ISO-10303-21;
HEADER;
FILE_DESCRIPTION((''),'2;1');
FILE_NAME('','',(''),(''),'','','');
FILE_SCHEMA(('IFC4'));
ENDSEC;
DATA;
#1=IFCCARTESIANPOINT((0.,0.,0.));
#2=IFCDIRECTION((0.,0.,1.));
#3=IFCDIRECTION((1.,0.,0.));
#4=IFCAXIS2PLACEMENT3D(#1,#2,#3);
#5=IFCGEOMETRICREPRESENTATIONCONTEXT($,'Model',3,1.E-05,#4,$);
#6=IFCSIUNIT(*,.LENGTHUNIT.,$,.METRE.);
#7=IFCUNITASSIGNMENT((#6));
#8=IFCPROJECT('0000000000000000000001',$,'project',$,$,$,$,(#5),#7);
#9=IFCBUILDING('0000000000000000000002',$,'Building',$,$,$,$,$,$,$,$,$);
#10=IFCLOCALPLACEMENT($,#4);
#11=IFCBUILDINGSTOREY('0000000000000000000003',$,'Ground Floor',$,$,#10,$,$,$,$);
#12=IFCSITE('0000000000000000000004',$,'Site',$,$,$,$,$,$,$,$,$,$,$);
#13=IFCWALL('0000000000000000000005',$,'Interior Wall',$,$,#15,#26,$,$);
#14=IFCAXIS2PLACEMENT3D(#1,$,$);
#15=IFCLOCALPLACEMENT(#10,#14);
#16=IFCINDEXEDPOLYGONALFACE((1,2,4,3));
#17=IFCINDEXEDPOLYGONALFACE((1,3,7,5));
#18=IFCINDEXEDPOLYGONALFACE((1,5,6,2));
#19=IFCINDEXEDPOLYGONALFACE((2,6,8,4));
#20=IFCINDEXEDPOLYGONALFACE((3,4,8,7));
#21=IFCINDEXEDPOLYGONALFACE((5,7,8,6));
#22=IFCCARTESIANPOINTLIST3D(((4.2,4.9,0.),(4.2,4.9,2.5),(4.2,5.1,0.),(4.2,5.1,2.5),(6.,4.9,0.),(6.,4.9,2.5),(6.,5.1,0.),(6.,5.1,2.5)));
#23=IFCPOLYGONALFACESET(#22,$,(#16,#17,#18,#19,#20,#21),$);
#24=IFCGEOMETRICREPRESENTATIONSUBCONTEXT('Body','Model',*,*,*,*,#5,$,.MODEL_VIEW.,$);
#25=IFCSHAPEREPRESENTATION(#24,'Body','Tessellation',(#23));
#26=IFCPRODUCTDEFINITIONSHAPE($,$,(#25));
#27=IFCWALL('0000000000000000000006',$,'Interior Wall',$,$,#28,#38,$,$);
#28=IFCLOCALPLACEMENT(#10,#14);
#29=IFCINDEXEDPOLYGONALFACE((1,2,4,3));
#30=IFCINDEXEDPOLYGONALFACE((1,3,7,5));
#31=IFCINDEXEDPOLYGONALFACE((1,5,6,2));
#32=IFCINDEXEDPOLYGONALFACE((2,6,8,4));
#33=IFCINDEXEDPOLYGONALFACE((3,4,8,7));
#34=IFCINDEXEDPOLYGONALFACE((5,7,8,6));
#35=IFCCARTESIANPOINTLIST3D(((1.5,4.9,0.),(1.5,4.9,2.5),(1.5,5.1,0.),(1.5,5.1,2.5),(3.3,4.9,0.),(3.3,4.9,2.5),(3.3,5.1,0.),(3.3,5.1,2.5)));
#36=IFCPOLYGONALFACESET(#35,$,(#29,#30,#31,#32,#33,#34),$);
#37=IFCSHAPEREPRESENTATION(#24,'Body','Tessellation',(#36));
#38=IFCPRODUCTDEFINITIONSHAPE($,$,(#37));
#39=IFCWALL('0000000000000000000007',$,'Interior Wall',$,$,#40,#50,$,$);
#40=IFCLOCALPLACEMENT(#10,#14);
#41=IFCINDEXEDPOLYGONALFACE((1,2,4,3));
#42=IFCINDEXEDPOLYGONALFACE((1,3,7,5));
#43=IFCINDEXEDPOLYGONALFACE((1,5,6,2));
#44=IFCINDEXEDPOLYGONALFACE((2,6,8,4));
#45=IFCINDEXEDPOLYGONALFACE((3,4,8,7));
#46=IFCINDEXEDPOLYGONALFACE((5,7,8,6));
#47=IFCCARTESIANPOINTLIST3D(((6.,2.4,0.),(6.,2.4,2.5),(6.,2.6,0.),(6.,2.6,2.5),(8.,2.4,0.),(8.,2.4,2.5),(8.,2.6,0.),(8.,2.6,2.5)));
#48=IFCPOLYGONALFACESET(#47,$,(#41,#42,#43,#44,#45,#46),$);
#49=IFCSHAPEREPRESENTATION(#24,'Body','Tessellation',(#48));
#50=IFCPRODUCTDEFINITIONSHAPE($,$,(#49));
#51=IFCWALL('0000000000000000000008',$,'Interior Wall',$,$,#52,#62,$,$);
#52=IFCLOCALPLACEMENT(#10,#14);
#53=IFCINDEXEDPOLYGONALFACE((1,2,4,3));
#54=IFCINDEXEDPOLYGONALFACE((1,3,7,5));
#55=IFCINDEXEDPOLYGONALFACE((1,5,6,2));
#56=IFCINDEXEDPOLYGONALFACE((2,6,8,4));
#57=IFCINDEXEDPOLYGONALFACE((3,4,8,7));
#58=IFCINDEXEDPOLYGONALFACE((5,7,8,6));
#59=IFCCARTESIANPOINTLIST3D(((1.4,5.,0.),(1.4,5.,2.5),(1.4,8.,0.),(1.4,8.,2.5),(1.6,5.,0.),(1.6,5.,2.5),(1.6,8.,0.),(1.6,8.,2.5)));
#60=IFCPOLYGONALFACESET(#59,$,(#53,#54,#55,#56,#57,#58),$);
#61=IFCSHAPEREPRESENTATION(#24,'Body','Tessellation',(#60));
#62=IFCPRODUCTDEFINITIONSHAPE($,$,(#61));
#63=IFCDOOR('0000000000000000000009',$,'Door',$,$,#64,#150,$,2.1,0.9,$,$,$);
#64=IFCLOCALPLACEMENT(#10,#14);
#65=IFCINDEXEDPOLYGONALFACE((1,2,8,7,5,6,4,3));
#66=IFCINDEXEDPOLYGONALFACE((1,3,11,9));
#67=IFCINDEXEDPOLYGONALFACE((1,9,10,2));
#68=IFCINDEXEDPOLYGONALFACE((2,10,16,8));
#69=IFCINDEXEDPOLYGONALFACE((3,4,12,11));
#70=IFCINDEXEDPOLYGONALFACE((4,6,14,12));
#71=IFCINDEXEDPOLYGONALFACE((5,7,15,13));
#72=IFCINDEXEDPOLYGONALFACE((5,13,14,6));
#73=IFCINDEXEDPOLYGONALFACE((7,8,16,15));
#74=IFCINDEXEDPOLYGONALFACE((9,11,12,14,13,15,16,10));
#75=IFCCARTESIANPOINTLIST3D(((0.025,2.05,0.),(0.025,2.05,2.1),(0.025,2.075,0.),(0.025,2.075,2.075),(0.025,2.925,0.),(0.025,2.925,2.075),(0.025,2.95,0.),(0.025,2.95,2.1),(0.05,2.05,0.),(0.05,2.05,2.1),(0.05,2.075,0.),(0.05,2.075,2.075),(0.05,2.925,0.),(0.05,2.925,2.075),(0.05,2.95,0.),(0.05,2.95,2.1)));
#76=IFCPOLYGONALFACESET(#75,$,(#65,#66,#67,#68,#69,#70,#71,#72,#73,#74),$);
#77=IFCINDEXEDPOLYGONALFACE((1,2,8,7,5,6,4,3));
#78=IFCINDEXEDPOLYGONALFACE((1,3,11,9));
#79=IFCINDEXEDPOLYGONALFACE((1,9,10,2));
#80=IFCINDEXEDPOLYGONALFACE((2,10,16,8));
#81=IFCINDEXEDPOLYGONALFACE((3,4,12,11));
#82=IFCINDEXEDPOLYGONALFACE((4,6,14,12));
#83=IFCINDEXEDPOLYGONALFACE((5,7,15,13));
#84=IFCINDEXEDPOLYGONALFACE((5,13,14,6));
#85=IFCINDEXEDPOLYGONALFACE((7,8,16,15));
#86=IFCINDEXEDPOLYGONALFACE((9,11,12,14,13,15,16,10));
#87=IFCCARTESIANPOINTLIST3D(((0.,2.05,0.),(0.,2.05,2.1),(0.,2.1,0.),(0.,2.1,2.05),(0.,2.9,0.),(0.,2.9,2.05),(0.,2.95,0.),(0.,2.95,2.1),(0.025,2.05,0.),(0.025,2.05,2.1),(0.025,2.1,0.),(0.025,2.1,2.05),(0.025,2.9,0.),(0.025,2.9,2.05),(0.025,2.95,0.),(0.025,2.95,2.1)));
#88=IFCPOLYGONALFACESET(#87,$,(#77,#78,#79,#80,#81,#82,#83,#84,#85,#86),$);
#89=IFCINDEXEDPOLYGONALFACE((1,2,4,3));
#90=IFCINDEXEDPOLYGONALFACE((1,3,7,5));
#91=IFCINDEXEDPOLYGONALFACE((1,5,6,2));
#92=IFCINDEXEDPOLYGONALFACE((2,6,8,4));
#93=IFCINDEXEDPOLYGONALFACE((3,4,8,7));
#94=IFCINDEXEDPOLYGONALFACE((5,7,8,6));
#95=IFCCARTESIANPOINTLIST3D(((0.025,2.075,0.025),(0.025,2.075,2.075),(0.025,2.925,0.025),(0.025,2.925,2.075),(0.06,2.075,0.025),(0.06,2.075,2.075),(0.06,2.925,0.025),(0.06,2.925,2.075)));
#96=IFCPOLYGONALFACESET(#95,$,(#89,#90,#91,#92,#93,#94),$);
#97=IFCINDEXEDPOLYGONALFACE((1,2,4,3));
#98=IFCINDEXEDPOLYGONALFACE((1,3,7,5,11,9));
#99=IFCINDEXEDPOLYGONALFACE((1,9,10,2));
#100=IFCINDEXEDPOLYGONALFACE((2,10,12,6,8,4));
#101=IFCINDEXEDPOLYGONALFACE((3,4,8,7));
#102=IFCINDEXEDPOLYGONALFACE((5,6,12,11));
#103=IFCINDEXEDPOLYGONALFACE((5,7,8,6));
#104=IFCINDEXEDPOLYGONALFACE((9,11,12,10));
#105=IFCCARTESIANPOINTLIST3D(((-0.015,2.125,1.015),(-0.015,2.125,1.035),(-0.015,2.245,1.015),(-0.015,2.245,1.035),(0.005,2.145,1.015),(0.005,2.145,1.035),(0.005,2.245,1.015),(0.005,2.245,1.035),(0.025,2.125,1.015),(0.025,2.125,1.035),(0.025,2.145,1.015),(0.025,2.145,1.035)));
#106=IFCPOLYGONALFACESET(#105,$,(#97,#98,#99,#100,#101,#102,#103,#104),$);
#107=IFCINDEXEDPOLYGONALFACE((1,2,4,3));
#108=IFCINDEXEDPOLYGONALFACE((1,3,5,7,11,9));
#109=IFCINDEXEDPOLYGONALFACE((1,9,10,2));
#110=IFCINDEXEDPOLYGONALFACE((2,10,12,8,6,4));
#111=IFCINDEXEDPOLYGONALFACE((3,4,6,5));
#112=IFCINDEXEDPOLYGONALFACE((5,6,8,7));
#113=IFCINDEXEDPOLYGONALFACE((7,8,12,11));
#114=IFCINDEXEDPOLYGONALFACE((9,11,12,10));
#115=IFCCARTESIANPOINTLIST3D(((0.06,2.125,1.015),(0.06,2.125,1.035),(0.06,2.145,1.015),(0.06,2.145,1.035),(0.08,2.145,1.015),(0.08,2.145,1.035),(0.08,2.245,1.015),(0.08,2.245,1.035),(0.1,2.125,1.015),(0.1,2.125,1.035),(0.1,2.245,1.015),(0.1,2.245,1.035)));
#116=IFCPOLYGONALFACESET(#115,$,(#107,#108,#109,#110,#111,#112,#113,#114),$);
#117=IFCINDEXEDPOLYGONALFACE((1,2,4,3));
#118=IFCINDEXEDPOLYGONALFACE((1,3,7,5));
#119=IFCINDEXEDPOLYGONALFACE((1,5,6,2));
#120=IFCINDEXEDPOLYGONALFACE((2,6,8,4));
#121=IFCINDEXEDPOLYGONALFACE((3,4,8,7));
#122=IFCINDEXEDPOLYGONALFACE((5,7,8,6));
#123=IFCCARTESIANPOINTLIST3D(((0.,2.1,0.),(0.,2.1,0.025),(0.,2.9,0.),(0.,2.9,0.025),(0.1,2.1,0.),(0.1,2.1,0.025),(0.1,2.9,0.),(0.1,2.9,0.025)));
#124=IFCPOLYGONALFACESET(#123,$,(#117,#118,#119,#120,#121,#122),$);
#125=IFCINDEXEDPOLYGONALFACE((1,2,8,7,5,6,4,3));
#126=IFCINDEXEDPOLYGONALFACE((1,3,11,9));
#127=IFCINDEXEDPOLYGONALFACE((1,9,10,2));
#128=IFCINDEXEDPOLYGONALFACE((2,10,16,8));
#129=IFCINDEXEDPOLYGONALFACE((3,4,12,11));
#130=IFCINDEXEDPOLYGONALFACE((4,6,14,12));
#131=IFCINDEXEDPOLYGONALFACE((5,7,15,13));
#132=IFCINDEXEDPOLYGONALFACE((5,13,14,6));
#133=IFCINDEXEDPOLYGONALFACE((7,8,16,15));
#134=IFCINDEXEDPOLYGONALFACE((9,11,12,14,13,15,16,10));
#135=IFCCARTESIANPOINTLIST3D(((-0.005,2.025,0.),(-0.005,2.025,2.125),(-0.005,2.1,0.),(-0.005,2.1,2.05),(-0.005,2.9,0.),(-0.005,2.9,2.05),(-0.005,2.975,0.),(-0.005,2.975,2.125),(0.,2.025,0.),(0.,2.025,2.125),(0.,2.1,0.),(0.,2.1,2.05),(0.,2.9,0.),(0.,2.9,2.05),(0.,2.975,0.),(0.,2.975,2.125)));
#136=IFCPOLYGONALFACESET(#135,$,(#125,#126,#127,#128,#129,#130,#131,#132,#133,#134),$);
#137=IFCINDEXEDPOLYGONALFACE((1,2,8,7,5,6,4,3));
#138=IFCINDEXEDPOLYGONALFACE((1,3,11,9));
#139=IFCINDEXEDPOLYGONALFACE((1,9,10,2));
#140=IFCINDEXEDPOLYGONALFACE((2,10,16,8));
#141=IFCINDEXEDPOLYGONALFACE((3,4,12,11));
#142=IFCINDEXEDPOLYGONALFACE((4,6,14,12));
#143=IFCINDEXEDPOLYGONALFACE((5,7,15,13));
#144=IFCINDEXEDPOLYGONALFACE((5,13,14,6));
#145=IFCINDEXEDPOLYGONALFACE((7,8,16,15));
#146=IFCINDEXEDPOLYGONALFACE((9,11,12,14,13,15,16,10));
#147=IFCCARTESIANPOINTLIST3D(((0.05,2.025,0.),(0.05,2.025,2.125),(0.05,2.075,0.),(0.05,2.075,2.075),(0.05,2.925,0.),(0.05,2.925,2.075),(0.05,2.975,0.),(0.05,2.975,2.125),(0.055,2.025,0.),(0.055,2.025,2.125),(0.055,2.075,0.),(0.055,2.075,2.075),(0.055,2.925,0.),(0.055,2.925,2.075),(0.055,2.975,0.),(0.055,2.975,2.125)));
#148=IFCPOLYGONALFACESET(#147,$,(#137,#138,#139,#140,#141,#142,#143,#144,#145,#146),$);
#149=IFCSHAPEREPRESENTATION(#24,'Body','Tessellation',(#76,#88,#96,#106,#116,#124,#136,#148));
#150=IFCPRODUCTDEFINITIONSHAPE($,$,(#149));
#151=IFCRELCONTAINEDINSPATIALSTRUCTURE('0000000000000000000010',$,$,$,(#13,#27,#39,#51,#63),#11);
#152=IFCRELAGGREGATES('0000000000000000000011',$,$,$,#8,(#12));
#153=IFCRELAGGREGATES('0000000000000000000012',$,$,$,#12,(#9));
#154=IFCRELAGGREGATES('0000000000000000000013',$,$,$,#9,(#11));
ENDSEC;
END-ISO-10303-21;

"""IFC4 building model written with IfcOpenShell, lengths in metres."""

from ifc_helpers import new_model, si_unit, frame, origin_with_axes, place, context, subcontext, project, spatial, line, indexed_curve, outline, extrude, element, save


model = new_model("IFC4")

# Units and contexts
model_context = context("Model", 3, precision=1e-05, world=origin_with_axes())
body_context = subcontext(model_context, "Body", "Model", "MODEL_VIEW")
ifc_project = project(units=[si_unit("LENGTHUNIT", "METRE")], contexts=[model_context])

# Site, building, storey
site = spatial("IfcSite", under=ifc_project, Name="Site")
building = spatial("IfcBuilding", under=site, Name="Building")
storey_placement = place(None, origin_with_axes())
storey = spatial("IfcBuildingStorey", under=building, at=storey_placement, Name="Ground Floor")

# Walls
for number, where, z_axis, x_axis, name in (
    (1, (6.0, 5.0, 0.0), (0.0, 0.0, 1.0), (-1.0, 0.0, 0.0), "Interior Wall"),
    (2, (3.3, 5.0, 0.0), (0.0, 0.0, 1.0), (-1.0, 0.0, 0.0), "Interior Wall"),
):
    element("IfcWall", number, at=place(storey_placement, frame(where, z_axis=z_axis, x_axis=x_axis)), inside=storey, Name=name, context=body_context, shape_type="SweptSolid", body=[
        extrude(outline(indexed_curve([(0.0, 0.0), (0.0, 0.2), (1.8, 0.2), (1.8, 0.0), (0.0, 0.0)], self_intersect=False)), frame((0.0, -0.1, 0.0), z_axis=(0.0, 0.0, 1.0), x_axis=(1.0, 0.0, 0.0)), (0.0, 0.0, 1.0), 2.5),
    ])
wall_1_placement = place(storey_placement, frame((8.0, 2.5, 0.0), z_axis=(0.0, 0.0, 1.0), x_axis=(-1.0, 0.0, 0.0)))
element("IfcWall", 3, at=wall_1_placement, inside=storey, Name="Interior Wall", context=body_context, shape_type="SweptSolid", body=[
    extrude(outline(indexed_curve([(0.0, 0.0), (0.0, 0.2), (2.0, 0.2), (2.0, 0.0), (0.0, 0.0)], self_intersect=False)), frame((0.0, -0.1, 0.0), z_axis=(0.0, 0.0, 1.0), x_axis=(1.0, 0.0, 0.0)), (0.0, 0.0, 1.0), 2.5),
])
wall_2_placement = place(storey_placement, frame((1.5, 5.0, 0.0), z_axis=(0.0, 0.0, 1.0), x_axis=(0.0, 1.0, 0.0)))
element("IfcWall", 4, at=wall_2_placement, inside=storey, Name="Interior Wall", context=body_context, shape_type="SweptSolid", body=[
    extrude(outline(indexed_curve([(0.0, 0.0), (0.0, 0.2), (3.0, 0.2), (3.0, 0.0), (0.0, 0.0)], self_intersect=False)), frame((0.0, -0.1, 0.0), z_axis=(0.0, 0.0, 1.0), x_axis=(1.0, 0.0, 0.0)), (0.0, 0.0, 1.0), 2.5),
])

# Door
door_1_placement = place(storey_placement, frame((0.0, 2.95, 0.0), z_axis=(0.0, 0.0, 1.0), x_axis=(0.0, -1.0, 0.0)))
element("IfcDoor", 5, at=door_1_placement, inside=storey, Name="Door", OverallHeight=2.1, OverallWidth=0.9, context=body_context, shape_type="SweptSolid", body=[
    extrude(outline(indexed_curve([(0.0, 0.0), (0.0, 2.1), (0.9, 2.1), (0.9, 0.0), (0.875, 0.0), (0.875, 2.075), (0.025, 2.075), (0.025, 0.0)], segments=[line(1, 2, 3, 4, 5, 6, 7, 8, 1)])), frame((0.0, 0.025, 0.0), z_axis=(0.0, -1.0, 0.0), x_axis=(1.0, 0.0, 0.0)), (0.0, 0.0, -1.0), 0.025),
    extrude(outline(indexed_curve([(0.0, 0.0), (0.0, 2.1), (0.9, 2.1), (0.9, 0.0), (0.85, 0.0), (0.85, 2.05), (0.05, 2.05), (0.05, 0.0)], segments=[line(1, 2, 3, 4, 5, 6, 7, 8, 1)])), frame((0.0, 0.0, 0.0), z_axis=(0.0, -1.0, 0.0), x_axis=(1.0, 0.0, 0.0)), (0.0, 0.0, -1.0), 0.025),
    extrude(outline(indexed_curve([(0.0, 0.0), (0.85, 0.0), (0.85, 0.035), (0.0, 0.035)], segments=[line(1, 2, 3, 4, 1)])), frame((0.025, 0.025, 0.025), z_axis=(0.0, 0.0, 1.0), x_axis=(1.0, 0.0, 0.0)), (0.0, 0.0, 1.0), 2.05),
    extrude(outline(indexed_curve([(0.0, 0.0), (0.0, -0.04), (-0.12, -0.04), (-0.12, -0.02), (-0.02, -0.02), (-0.02, 0.0)], segments=[line(1, 2, 3, 4, 5, 6, 1)])), frame((0.825, 0.025, 1.015), z_axis=(0.0, 0.0, 1.0), x_axis=(1.0, 0.0, 0.0)), (0.0, 0.0, 1.0), 0.02),
    extrude(outline(indexed_curve([(0.0, 0.0), (0.0, 0.04), (-0.12, 0.04), (-0.12, 0.02), (-0.02, 0.02), (-0.02, 0.0)], segments=[line(1, 2, 3, 4, 5, 6, 1)])), frame((0.825, 0.06, 1.015), z_axis=(0.0, 0.0, 1.0), x_axis=(1.0, 0.0, 0.0)), (0.0, 0.0, 1.0), 0.02),
    extrude(outline(indexed_curve([(0.0, 0.0), (0.8, 0.0), (0.8, 0.1), (0.0, 0.1)], segments=[line(1, 2, 3, 4, 1)])), frame((0.05, 0.0, 0.0), z_axis=(0.0, 0.0, 1.0), x_axis=(1.0, 0.0, 0.0)), (0.0, 0.0, 1.0), 0.025),
    extrude(outline(indexed_curve([(0.0, 0.0), (0.0, 2.125), (0.95, 2.125), (0.95, 0.0), (0.875, 0.0), (0.875, 2.05), (0.075, 2.05), (0.075, 0.0)], segments=[line(1, 2, 3, 4, 5, 6, 7, 8, 1)])), frame((-0.025, -0.005, 0.0), z_axis=(0.0, -1.0, 0.0), x_axis=(1.0, 0.0, 0.0)), (0.0, 0.0, -1.0), 0.005),
    extrude(outline(indexed_curve([(0.0, 0.0), (0.0, 2.125), (0.95, 2.125), (0.95, 0.0), (0.9, 0.0), (0.9, 2.075), (0.05, 2.075), (0.05, 0.0)], segments=[line(1, 2, 3, 4, 5, 6, 7, 8, 1)])), frame((-0.025, 0.05, 0.0), z_axis=(0.0, -1.0, 0.0), x_axis=(1.0, 0.0, 0.0)), (0.0, 0.0, -1.0), 0.005),
])

save(model, "model.ifc")
